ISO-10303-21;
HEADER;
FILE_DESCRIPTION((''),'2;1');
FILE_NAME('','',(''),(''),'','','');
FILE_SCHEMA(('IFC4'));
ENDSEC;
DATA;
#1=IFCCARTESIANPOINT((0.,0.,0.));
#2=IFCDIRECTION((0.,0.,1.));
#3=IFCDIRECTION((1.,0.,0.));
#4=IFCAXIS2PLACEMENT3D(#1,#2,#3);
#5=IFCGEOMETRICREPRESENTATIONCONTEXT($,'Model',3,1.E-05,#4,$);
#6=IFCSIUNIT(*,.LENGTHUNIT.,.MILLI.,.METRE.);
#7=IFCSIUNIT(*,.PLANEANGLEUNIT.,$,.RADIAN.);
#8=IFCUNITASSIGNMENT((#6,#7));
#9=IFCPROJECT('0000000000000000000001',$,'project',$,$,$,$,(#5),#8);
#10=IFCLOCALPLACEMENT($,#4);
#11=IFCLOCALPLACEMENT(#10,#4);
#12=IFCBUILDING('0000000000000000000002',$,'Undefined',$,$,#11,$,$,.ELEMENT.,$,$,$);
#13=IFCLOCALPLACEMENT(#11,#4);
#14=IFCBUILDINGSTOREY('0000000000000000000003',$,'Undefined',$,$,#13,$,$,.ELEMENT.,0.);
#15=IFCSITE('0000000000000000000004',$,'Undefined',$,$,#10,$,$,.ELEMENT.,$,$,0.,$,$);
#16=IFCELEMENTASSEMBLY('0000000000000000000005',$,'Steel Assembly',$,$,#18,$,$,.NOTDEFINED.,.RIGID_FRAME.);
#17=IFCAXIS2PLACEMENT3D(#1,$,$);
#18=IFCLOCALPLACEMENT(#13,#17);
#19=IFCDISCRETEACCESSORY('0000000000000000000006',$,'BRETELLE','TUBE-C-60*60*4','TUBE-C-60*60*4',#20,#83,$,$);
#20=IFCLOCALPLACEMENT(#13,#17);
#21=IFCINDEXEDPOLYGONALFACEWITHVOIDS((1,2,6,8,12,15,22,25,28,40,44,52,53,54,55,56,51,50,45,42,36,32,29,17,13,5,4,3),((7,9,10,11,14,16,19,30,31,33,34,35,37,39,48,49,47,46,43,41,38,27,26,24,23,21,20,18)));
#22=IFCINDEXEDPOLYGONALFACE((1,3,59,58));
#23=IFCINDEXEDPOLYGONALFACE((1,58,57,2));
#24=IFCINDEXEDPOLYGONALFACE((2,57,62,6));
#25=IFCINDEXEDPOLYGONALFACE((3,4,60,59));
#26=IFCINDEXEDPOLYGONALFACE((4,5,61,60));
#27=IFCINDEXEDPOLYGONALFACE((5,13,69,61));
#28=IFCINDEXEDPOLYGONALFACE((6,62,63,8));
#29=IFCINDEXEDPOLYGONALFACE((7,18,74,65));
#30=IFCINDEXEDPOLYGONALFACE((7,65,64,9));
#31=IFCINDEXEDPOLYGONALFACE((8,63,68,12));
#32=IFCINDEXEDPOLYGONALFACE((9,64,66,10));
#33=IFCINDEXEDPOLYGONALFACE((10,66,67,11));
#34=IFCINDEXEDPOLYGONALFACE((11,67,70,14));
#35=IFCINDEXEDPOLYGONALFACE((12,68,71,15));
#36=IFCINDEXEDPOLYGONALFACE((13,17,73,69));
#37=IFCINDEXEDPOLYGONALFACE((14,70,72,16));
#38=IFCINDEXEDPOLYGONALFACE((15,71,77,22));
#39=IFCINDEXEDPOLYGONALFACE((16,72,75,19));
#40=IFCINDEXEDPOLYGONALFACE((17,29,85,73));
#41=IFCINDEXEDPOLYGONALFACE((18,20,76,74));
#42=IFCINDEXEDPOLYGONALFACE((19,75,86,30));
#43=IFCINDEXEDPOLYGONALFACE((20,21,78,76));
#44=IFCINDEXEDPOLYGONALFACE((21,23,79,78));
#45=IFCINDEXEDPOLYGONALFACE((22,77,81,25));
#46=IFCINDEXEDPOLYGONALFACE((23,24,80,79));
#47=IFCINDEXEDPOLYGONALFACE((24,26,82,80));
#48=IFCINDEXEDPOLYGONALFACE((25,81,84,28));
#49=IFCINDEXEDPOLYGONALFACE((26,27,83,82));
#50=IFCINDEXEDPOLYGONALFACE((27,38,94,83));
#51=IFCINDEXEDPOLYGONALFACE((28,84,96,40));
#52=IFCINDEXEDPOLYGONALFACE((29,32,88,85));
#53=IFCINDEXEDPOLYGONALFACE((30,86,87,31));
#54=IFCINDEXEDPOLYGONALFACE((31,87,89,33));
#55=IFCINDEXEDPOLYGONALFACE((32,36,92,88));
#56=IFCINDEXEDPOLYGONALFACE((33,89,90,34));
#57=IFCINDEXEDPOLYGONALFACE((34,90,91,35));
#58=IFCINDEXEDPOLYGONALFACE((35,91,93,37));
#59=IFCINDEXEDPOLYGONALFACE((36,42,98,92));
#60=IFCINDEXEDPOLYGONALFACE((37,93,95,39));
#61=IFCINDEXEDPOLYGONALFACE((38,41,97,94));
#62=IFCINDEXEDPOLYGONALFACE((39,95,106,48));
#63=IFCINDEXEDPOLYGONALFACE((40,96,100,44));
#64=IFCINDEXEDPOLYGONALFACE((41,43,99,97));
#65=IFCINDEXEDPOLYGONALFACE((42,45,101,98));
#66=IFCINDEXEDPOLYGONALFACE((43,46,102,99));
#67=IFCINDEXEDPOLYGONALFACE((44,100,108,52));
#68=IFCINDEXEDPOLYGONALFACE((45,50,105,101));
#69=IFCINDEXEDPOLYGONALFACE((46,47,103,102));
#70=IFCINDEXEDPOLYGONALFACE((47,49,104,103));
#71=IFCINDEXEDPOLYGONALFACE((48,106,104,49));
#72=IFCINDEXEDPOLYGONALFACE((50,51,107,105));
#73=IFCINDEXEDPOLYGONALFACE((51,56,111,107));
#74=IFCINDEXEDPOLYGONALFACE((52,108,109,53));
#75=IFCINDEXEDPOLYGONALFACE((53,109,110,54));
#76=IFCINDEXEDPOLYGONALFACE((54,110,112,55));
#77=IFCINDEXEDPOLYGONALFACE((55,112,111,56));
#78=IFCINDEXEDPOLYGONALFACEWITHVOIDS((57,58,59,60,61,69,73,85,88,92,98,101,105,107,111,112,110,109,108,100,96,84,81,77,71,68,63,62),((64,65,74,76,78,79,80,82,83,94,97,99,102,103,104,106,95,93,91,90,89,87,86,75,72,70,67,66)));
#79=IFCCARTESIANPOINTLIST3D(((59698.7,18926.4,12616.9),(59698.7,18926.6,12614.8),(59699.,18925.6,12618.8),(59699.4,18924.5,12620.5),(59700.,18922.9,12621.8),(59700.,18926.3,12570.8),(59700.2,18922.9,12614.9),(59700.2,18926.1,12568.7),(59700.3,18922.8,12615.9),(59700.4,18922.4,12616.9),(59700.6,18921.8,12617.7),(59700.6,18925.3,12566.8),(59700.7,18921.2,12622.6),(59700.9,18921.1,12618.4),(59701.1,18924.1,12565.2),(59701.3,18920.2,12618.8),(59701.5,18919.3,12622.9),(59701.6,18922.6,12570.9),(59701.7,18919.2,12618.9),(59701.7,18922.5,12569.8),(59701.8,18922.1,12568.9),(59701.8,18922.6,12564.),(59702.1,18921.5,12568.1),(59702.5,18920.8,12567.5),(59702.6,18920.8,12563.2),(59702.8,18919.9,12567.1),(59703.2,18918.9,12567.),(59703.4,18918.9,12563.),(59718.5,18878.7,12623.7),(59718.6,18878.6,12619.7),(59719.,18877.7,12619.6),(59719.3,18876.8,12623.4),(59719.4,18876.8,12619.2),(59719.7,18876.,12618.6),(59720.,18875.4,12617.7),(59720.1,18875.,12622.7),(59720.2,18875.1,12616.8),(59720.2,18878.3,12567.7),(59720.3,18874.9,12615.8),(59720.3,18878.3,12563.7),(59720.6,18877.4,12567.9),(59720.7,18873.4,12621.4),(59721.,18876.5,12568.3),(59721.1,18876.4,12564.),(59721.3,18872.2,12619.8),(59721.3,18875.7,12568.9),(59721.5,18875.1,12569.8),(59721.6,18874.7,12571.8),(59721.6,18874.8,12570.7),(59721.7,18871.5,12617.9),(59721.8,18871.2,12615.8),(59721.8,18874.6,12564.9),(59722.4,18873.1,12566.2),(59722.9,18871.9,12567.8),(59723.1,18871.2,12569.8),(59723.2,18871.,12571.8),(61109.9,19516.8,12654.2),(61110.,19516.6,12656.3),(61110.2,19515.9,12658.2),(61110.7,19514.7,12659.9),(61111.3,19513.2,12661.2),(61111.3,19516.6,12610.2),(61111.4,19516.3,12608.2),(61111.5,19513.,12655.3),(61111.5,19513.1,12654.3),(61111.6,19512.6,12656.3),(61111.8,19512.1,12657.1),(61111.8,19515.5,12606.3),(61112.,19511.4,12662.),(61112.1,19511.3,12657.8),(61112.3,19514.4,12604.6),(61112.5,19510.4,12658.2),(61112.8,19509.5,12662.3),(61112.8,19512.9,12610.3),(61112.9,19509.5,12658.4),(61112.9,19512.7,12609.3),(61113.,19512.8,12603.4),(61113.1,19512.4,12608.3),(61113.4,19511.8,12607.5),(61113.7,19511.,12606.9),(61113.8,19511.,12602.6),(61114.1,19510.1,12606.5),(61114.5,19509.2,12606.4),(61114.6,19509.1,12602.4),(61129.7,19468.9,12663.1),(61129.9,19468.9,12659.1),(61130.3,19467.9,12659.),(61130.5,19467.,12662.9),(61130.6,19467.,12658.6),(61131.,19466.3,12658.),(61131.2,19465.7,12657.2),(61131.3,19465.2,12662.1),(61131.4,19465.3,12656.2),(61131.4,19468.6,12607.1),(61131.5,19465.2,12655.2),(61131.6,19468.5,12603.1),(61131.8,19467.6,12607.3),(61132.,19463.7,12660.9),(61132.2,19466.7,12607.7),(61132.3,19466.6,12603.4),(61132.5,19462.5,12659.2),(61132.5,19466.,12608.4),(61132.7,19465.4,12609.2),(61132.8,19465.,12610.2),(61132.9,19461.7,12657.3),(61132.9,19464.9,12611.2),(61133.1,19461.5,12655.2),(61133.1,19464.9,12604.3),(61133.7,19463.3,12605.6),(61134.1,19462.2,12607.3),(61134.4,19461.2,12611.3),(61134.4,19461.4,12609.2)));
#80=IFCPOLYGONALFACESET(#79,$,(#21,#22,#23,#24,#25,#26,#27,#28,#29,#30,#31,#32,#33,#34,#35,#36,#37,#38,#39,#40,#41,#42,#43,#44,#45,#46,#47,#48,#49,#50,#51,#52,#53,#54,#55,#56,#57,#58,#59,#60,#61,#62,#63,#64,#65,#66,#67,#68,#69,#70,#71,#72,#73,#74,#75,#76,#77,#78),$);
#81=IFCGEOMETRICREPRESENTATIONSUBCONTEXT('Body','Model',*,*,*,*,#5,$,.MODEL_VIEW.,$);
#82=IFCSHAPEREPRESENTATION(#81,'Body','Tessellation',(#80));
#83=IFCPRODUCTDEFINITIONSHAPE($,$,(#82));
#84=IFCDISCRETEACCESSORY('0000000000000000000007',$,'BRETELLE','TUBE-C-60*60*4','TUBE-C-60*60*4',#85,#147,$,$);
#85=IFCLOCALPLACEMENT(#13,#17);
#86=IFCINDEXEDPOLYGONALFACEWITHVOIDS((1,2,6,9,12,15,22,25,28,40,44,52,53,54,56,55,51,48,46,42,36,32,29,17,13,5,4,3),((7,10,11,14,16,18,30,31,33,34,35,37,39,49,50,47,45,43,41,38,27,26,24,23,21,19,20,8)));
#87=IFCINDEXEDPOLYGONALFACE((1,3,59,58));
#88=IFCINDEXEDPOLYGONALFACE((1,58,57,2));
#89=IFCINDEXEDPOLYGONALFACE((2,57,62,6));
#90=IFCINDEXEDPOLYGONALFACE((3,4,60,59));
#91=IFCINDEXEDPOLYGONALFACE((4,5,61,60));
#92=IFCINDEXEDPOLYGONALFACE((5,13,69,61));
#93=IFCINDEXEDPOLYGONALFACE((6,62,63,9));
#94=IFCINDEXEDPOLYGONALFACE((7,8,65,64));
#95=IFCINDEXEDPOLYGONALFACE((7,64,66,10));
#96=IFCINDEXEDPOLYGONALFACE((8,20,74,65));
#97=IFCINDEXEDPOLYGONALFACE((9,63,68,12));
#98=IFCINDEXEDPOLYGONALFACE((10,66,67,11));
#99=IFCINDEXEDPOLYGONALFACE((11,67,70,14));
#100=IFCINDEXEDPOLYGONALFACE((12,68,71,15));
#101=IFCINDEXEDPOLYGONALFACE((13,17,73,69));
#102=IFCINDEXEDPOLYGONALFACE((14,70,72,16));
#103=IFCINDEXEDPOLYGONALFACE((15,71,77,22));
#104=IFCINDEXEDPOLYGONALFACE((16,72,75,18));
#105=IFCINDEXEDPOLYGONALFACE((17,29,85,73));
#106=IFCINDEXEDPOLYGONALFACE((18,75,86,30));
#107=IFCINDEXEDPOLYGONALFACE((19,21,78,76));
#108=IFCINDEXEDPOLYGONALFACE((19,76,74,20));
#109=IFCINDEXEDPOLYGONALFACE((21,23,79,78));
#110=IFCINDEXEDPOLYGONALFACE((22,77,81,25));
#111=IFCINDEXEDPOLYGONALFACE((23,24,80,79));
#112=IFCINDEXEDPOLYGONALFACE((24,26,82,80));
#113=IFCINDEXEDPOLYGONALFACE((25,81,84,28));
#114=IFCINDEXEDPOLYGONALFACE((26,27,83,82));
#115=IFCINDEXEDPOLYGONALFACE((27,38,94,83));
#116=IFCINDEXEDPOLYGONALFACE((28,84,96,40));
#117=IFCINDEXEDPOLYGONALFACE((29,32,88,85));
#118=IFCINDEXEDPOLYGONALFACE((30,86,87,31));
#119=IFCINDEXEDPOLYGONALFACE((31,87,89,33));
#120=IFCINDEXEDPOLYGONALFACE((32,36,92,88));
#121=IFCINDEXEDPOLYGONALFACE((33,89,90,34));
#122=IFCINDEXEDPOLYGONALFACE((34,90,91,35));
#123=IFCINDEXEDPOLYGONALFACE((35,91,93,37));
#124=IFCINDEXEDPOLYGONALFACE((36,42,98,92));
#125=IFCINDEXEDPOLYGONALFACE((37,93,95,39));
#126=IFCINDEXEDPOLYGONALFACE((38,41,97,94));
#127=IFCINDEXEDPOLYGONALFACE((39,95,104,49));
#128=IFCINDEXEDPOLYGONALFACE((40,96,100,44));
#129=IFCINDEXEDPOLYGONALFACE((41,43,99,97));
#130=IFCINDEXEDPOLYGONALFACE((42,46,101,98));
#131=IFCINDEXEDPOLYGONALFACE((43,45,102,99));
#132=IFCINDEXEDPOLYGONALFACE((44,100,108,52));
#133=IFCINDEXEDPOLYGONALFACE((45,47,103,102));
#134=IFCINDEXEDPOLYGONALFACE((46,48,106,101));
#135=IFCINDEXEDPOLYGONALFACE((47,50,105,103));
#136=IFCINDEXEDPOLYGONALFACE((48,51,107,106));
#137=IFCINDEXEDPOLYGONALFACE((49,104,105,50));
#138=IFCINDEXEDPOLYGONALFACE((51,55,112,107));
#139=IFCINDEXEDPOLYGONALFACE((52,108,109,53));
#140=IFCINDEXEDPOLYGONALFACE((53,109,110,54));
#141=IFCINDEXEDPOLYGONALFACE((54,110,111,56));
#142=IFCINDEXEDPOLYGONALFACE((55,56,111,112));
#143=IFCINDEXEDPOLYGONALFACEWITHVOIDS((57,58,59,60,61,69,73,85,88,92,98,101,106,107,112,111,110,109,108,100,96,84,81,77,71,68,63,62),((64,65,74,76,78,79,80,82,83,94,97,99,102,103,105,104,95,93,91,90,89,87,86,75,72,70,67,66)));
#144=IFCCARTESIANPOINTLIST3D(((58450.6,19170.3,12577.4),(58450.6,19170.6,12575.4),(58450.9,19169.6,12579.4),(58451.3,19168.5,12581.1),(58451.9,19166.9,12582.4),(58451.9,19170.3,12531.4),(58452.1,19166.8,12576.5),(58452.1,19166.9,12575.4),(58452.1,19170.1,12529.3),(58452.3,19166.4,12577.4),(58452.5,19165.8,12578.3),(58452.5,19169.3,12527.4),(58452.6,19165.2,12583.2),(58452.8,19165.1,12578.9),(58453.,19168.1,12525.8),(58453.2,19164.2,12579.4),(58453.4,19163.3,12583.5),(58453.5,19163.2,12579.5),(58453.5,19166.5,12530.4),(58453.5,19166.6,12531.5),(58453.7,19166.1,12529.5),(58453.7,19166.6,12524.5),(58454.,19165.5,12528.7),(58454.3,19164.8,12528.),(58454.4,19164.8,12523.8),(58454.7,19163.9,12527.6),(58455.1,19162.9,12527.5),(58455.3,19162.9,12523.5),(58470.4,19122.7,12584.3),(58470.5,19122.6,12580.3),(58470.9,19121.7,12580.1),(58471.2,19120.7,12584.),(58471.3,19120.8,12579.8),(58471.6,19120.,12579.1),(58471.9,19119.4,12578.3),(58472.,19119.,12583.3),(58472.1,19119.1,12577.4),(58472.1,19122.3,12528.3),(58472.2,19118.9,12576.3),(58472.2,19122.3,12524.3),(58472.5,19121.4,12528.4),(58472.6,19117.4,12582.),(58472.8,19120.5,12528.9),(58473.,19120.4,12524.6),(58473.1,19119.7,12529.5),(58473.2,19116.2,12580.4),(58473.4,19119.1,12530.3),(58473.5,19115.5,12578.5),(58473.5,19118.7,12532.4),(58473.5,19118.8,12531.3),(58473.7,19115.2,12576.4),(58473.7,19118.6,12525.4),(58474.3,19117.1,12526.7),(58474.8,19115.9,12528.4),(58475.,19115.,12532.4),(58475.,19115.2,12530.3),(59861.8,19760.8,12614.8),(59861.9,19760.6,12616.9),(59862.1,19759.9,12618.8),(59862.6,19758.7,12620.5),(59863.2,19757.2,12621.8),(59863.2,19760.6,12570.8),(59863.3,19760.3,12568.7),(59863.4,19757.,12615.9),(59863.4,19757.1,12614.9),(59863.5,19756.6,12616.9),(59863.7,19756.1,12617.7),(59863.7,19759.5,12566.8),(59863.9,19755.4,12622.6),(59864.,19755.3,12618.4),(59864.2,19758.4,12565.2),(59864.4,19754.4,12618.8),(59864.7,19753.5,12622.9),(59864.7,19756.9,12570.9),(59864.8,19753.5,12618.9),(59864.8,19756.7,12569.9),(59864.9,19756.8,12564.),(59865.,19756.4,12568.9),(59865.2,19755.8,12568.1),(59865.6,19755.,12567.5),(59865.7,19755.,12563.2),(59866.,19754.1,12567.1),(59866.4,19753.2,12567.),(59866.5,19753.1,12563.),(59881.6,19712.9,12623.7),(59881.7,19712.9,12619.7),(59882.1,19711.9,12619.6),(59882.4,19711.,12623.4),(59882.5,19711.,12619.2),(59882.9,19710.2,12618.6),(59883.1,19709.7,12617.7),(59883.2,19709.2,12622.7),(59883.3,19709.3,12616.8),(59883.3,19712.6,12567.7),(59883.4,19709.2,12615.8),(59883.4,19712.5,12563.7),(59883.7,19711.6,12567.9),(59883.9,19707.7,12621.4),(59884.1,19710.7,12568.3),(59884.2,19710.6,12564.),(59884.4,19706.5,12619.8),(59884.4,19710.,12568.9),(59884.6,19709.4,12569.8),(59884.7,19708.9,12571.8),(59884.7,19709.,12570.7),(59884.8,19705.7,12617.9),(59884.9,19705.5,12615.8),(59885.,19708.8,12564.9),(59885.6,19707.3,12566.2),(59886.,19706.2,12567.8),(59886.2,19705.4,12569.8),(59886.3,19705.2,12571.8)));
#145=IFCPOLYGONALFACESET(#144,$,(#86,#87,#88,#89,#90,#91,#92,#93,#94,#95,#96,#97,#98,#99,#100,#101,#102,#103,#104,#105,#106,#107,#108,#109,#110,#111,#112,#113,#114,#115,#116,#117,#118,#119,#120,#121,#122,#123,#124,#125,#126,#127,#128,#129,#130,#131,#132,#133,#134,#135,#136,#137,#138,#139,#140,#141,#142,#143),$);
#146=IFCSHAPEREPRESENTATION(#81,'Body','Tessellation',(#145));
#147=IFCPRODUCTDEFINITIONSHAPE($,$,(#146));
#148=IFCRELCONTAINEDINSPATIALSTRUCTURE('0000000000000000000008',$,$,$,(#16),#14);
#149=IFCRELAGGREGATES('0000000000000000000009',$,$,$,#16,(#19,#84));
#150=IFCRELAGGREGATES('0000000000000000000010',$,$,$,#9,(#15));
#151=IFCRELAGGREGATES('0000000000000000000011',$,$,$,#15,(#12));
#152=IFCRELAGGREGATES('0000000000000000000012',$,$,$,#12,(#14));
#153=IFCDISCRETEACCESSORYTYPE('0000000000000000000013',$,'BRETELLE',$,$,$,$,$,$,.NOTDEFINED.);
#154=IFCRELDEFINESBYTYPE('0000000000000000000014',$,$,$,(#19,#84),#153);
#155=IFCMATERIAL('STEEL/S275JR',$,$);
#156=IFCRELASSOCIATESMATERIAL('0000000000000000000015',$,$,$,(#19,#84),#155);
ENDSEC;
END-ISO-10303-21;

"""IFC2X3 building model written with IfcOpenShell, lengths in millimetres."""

from ifc_helpers import new_model, si_unit, frame, origin_with_axes, origin_2d_with_axis, place, context, subcontext, project, spatial, hollow_rectangle, extrude, material, type_object, element, aggregate, save


model = new_model("IFC2X3")

# Units and contexts
model_context = context("Model", 3, precision=1e-05, world=origin_with_axes())
body_context = subcontext(model_context, "Body", "Model", "MODEL_VIEW")
ifc_project = project(units=[si_unit("LENGTHUNIT", "METRE", prefix="MILLI"), si_unit("PLANEANGLEUNIT", "RADIAN")], contexts=[model_context])

# Site, building, storey
site_placement = place(None, origin_with_axes())
site = spatial("IfcSite", under=ifc_project, at=site_placement, Name="Undefined", CompositionType="ELEMENT", RefElevation=0.0)
building_placement = place(site_placement, origin_with_axes())
building = spatial("IfcBuilding", under=site, at=building_placement, Name="Undefined", CompositionType="ELEMENT")
storey_placement = place(building_placement, origin_with_axes())
storey = spatial("IfcBuildingStorey", under=building, at=storey_placement, Name="Undefined", CompositionType="ELEMENT", Elevation=0.0)

# Shared definitions
ifc_material_1 = material(Name="STEEL/S275JR")

# Element assembly, discrete accessories
assembly_1_placement = place(storey_placement, origin_with_axes())
assembly_1 = element("IfcElementAssembly", 1, at=assembly_1_placement, inside=storey, Name="Steel Assembly", AssemblyPlace="NOTDEFINED", PredefinedType="RIGID_FRAME")
discrete_accessory_type_1 = type_object("IfcDiscreteAccessoryType", Name="BRETELLE")
discrete_accessory_1_placement = place(assembly_1_placement, frame((61122.1, 19489.0, 12632.7), z_axis=(-0.385384, 0.922596, -0.017211), x_axis=(-0.922255, -0.385722, -0.025763)))
discrete_accessory_1 = element("IfcDiscreteAccessory", 2, at=discrete_accessory_1_placement, type_object=discrete_accessory_type_1, material=ifc_material_1, Name="BRETELLE", Description="TUBE-C-60*60*4", ObjectType="TUBE-C-60*60*4", context=body_context, shape_type="SweptSolid", body=[
    extrude(hollow_rectangle(XDim=60.0, YDim=60.0, WallThickness=4.0, InnerFilletRadius=4.0, OuterFilletRadius=8.0, at=origin_2d_with_axis()), frame((1530.2, 0.0, 0.0), z_axis=(-1.0, 0.0, 0.0), x_axis=(0.0, -1.0, 0.0)), (0.0, 0.0, 1.0), 1530.2),
])
discrete_accessory_2_placement = place(assembly_1_placement, frame((59874.0, 19733.0, 12593.3), z_axis=(-0.385384, 0.922596, -0.017211), x_axis=(-0.922255, -0.385722, -0.025763)))
discrete_accessory_2 = element("IfcDiscreteAccessory", 3, at=discrete_accessory_2_placement, type_object=discrete_accessory_type_1, material=ifc_material_1, Name="BRETELLE", Description="TUBE-C-60*60*4", ObjectType="TUBE-C-60*60*4", context=body_context, shape_type="SweptSolid", body=[
    extrude(hollow_rectangle(XDim=60.0, YDim=60.0, WallThickness=4.0, InnerFilletRadius=4.0, OuterFilletRadius=8.0, at=origin_2d_with_axis()), frame((1530.2, 0.0, 0.0), z_axis=(-1.0, 0.0, 0.0), x_axis=(0.0, -1.0, 0.0)), (0.0, 0.0, 1.0), 1530.2),
])
aggregate(assembly_1, [discrete_accessory_1, discrete_accessory_2])

save(model, "model.ifc")
